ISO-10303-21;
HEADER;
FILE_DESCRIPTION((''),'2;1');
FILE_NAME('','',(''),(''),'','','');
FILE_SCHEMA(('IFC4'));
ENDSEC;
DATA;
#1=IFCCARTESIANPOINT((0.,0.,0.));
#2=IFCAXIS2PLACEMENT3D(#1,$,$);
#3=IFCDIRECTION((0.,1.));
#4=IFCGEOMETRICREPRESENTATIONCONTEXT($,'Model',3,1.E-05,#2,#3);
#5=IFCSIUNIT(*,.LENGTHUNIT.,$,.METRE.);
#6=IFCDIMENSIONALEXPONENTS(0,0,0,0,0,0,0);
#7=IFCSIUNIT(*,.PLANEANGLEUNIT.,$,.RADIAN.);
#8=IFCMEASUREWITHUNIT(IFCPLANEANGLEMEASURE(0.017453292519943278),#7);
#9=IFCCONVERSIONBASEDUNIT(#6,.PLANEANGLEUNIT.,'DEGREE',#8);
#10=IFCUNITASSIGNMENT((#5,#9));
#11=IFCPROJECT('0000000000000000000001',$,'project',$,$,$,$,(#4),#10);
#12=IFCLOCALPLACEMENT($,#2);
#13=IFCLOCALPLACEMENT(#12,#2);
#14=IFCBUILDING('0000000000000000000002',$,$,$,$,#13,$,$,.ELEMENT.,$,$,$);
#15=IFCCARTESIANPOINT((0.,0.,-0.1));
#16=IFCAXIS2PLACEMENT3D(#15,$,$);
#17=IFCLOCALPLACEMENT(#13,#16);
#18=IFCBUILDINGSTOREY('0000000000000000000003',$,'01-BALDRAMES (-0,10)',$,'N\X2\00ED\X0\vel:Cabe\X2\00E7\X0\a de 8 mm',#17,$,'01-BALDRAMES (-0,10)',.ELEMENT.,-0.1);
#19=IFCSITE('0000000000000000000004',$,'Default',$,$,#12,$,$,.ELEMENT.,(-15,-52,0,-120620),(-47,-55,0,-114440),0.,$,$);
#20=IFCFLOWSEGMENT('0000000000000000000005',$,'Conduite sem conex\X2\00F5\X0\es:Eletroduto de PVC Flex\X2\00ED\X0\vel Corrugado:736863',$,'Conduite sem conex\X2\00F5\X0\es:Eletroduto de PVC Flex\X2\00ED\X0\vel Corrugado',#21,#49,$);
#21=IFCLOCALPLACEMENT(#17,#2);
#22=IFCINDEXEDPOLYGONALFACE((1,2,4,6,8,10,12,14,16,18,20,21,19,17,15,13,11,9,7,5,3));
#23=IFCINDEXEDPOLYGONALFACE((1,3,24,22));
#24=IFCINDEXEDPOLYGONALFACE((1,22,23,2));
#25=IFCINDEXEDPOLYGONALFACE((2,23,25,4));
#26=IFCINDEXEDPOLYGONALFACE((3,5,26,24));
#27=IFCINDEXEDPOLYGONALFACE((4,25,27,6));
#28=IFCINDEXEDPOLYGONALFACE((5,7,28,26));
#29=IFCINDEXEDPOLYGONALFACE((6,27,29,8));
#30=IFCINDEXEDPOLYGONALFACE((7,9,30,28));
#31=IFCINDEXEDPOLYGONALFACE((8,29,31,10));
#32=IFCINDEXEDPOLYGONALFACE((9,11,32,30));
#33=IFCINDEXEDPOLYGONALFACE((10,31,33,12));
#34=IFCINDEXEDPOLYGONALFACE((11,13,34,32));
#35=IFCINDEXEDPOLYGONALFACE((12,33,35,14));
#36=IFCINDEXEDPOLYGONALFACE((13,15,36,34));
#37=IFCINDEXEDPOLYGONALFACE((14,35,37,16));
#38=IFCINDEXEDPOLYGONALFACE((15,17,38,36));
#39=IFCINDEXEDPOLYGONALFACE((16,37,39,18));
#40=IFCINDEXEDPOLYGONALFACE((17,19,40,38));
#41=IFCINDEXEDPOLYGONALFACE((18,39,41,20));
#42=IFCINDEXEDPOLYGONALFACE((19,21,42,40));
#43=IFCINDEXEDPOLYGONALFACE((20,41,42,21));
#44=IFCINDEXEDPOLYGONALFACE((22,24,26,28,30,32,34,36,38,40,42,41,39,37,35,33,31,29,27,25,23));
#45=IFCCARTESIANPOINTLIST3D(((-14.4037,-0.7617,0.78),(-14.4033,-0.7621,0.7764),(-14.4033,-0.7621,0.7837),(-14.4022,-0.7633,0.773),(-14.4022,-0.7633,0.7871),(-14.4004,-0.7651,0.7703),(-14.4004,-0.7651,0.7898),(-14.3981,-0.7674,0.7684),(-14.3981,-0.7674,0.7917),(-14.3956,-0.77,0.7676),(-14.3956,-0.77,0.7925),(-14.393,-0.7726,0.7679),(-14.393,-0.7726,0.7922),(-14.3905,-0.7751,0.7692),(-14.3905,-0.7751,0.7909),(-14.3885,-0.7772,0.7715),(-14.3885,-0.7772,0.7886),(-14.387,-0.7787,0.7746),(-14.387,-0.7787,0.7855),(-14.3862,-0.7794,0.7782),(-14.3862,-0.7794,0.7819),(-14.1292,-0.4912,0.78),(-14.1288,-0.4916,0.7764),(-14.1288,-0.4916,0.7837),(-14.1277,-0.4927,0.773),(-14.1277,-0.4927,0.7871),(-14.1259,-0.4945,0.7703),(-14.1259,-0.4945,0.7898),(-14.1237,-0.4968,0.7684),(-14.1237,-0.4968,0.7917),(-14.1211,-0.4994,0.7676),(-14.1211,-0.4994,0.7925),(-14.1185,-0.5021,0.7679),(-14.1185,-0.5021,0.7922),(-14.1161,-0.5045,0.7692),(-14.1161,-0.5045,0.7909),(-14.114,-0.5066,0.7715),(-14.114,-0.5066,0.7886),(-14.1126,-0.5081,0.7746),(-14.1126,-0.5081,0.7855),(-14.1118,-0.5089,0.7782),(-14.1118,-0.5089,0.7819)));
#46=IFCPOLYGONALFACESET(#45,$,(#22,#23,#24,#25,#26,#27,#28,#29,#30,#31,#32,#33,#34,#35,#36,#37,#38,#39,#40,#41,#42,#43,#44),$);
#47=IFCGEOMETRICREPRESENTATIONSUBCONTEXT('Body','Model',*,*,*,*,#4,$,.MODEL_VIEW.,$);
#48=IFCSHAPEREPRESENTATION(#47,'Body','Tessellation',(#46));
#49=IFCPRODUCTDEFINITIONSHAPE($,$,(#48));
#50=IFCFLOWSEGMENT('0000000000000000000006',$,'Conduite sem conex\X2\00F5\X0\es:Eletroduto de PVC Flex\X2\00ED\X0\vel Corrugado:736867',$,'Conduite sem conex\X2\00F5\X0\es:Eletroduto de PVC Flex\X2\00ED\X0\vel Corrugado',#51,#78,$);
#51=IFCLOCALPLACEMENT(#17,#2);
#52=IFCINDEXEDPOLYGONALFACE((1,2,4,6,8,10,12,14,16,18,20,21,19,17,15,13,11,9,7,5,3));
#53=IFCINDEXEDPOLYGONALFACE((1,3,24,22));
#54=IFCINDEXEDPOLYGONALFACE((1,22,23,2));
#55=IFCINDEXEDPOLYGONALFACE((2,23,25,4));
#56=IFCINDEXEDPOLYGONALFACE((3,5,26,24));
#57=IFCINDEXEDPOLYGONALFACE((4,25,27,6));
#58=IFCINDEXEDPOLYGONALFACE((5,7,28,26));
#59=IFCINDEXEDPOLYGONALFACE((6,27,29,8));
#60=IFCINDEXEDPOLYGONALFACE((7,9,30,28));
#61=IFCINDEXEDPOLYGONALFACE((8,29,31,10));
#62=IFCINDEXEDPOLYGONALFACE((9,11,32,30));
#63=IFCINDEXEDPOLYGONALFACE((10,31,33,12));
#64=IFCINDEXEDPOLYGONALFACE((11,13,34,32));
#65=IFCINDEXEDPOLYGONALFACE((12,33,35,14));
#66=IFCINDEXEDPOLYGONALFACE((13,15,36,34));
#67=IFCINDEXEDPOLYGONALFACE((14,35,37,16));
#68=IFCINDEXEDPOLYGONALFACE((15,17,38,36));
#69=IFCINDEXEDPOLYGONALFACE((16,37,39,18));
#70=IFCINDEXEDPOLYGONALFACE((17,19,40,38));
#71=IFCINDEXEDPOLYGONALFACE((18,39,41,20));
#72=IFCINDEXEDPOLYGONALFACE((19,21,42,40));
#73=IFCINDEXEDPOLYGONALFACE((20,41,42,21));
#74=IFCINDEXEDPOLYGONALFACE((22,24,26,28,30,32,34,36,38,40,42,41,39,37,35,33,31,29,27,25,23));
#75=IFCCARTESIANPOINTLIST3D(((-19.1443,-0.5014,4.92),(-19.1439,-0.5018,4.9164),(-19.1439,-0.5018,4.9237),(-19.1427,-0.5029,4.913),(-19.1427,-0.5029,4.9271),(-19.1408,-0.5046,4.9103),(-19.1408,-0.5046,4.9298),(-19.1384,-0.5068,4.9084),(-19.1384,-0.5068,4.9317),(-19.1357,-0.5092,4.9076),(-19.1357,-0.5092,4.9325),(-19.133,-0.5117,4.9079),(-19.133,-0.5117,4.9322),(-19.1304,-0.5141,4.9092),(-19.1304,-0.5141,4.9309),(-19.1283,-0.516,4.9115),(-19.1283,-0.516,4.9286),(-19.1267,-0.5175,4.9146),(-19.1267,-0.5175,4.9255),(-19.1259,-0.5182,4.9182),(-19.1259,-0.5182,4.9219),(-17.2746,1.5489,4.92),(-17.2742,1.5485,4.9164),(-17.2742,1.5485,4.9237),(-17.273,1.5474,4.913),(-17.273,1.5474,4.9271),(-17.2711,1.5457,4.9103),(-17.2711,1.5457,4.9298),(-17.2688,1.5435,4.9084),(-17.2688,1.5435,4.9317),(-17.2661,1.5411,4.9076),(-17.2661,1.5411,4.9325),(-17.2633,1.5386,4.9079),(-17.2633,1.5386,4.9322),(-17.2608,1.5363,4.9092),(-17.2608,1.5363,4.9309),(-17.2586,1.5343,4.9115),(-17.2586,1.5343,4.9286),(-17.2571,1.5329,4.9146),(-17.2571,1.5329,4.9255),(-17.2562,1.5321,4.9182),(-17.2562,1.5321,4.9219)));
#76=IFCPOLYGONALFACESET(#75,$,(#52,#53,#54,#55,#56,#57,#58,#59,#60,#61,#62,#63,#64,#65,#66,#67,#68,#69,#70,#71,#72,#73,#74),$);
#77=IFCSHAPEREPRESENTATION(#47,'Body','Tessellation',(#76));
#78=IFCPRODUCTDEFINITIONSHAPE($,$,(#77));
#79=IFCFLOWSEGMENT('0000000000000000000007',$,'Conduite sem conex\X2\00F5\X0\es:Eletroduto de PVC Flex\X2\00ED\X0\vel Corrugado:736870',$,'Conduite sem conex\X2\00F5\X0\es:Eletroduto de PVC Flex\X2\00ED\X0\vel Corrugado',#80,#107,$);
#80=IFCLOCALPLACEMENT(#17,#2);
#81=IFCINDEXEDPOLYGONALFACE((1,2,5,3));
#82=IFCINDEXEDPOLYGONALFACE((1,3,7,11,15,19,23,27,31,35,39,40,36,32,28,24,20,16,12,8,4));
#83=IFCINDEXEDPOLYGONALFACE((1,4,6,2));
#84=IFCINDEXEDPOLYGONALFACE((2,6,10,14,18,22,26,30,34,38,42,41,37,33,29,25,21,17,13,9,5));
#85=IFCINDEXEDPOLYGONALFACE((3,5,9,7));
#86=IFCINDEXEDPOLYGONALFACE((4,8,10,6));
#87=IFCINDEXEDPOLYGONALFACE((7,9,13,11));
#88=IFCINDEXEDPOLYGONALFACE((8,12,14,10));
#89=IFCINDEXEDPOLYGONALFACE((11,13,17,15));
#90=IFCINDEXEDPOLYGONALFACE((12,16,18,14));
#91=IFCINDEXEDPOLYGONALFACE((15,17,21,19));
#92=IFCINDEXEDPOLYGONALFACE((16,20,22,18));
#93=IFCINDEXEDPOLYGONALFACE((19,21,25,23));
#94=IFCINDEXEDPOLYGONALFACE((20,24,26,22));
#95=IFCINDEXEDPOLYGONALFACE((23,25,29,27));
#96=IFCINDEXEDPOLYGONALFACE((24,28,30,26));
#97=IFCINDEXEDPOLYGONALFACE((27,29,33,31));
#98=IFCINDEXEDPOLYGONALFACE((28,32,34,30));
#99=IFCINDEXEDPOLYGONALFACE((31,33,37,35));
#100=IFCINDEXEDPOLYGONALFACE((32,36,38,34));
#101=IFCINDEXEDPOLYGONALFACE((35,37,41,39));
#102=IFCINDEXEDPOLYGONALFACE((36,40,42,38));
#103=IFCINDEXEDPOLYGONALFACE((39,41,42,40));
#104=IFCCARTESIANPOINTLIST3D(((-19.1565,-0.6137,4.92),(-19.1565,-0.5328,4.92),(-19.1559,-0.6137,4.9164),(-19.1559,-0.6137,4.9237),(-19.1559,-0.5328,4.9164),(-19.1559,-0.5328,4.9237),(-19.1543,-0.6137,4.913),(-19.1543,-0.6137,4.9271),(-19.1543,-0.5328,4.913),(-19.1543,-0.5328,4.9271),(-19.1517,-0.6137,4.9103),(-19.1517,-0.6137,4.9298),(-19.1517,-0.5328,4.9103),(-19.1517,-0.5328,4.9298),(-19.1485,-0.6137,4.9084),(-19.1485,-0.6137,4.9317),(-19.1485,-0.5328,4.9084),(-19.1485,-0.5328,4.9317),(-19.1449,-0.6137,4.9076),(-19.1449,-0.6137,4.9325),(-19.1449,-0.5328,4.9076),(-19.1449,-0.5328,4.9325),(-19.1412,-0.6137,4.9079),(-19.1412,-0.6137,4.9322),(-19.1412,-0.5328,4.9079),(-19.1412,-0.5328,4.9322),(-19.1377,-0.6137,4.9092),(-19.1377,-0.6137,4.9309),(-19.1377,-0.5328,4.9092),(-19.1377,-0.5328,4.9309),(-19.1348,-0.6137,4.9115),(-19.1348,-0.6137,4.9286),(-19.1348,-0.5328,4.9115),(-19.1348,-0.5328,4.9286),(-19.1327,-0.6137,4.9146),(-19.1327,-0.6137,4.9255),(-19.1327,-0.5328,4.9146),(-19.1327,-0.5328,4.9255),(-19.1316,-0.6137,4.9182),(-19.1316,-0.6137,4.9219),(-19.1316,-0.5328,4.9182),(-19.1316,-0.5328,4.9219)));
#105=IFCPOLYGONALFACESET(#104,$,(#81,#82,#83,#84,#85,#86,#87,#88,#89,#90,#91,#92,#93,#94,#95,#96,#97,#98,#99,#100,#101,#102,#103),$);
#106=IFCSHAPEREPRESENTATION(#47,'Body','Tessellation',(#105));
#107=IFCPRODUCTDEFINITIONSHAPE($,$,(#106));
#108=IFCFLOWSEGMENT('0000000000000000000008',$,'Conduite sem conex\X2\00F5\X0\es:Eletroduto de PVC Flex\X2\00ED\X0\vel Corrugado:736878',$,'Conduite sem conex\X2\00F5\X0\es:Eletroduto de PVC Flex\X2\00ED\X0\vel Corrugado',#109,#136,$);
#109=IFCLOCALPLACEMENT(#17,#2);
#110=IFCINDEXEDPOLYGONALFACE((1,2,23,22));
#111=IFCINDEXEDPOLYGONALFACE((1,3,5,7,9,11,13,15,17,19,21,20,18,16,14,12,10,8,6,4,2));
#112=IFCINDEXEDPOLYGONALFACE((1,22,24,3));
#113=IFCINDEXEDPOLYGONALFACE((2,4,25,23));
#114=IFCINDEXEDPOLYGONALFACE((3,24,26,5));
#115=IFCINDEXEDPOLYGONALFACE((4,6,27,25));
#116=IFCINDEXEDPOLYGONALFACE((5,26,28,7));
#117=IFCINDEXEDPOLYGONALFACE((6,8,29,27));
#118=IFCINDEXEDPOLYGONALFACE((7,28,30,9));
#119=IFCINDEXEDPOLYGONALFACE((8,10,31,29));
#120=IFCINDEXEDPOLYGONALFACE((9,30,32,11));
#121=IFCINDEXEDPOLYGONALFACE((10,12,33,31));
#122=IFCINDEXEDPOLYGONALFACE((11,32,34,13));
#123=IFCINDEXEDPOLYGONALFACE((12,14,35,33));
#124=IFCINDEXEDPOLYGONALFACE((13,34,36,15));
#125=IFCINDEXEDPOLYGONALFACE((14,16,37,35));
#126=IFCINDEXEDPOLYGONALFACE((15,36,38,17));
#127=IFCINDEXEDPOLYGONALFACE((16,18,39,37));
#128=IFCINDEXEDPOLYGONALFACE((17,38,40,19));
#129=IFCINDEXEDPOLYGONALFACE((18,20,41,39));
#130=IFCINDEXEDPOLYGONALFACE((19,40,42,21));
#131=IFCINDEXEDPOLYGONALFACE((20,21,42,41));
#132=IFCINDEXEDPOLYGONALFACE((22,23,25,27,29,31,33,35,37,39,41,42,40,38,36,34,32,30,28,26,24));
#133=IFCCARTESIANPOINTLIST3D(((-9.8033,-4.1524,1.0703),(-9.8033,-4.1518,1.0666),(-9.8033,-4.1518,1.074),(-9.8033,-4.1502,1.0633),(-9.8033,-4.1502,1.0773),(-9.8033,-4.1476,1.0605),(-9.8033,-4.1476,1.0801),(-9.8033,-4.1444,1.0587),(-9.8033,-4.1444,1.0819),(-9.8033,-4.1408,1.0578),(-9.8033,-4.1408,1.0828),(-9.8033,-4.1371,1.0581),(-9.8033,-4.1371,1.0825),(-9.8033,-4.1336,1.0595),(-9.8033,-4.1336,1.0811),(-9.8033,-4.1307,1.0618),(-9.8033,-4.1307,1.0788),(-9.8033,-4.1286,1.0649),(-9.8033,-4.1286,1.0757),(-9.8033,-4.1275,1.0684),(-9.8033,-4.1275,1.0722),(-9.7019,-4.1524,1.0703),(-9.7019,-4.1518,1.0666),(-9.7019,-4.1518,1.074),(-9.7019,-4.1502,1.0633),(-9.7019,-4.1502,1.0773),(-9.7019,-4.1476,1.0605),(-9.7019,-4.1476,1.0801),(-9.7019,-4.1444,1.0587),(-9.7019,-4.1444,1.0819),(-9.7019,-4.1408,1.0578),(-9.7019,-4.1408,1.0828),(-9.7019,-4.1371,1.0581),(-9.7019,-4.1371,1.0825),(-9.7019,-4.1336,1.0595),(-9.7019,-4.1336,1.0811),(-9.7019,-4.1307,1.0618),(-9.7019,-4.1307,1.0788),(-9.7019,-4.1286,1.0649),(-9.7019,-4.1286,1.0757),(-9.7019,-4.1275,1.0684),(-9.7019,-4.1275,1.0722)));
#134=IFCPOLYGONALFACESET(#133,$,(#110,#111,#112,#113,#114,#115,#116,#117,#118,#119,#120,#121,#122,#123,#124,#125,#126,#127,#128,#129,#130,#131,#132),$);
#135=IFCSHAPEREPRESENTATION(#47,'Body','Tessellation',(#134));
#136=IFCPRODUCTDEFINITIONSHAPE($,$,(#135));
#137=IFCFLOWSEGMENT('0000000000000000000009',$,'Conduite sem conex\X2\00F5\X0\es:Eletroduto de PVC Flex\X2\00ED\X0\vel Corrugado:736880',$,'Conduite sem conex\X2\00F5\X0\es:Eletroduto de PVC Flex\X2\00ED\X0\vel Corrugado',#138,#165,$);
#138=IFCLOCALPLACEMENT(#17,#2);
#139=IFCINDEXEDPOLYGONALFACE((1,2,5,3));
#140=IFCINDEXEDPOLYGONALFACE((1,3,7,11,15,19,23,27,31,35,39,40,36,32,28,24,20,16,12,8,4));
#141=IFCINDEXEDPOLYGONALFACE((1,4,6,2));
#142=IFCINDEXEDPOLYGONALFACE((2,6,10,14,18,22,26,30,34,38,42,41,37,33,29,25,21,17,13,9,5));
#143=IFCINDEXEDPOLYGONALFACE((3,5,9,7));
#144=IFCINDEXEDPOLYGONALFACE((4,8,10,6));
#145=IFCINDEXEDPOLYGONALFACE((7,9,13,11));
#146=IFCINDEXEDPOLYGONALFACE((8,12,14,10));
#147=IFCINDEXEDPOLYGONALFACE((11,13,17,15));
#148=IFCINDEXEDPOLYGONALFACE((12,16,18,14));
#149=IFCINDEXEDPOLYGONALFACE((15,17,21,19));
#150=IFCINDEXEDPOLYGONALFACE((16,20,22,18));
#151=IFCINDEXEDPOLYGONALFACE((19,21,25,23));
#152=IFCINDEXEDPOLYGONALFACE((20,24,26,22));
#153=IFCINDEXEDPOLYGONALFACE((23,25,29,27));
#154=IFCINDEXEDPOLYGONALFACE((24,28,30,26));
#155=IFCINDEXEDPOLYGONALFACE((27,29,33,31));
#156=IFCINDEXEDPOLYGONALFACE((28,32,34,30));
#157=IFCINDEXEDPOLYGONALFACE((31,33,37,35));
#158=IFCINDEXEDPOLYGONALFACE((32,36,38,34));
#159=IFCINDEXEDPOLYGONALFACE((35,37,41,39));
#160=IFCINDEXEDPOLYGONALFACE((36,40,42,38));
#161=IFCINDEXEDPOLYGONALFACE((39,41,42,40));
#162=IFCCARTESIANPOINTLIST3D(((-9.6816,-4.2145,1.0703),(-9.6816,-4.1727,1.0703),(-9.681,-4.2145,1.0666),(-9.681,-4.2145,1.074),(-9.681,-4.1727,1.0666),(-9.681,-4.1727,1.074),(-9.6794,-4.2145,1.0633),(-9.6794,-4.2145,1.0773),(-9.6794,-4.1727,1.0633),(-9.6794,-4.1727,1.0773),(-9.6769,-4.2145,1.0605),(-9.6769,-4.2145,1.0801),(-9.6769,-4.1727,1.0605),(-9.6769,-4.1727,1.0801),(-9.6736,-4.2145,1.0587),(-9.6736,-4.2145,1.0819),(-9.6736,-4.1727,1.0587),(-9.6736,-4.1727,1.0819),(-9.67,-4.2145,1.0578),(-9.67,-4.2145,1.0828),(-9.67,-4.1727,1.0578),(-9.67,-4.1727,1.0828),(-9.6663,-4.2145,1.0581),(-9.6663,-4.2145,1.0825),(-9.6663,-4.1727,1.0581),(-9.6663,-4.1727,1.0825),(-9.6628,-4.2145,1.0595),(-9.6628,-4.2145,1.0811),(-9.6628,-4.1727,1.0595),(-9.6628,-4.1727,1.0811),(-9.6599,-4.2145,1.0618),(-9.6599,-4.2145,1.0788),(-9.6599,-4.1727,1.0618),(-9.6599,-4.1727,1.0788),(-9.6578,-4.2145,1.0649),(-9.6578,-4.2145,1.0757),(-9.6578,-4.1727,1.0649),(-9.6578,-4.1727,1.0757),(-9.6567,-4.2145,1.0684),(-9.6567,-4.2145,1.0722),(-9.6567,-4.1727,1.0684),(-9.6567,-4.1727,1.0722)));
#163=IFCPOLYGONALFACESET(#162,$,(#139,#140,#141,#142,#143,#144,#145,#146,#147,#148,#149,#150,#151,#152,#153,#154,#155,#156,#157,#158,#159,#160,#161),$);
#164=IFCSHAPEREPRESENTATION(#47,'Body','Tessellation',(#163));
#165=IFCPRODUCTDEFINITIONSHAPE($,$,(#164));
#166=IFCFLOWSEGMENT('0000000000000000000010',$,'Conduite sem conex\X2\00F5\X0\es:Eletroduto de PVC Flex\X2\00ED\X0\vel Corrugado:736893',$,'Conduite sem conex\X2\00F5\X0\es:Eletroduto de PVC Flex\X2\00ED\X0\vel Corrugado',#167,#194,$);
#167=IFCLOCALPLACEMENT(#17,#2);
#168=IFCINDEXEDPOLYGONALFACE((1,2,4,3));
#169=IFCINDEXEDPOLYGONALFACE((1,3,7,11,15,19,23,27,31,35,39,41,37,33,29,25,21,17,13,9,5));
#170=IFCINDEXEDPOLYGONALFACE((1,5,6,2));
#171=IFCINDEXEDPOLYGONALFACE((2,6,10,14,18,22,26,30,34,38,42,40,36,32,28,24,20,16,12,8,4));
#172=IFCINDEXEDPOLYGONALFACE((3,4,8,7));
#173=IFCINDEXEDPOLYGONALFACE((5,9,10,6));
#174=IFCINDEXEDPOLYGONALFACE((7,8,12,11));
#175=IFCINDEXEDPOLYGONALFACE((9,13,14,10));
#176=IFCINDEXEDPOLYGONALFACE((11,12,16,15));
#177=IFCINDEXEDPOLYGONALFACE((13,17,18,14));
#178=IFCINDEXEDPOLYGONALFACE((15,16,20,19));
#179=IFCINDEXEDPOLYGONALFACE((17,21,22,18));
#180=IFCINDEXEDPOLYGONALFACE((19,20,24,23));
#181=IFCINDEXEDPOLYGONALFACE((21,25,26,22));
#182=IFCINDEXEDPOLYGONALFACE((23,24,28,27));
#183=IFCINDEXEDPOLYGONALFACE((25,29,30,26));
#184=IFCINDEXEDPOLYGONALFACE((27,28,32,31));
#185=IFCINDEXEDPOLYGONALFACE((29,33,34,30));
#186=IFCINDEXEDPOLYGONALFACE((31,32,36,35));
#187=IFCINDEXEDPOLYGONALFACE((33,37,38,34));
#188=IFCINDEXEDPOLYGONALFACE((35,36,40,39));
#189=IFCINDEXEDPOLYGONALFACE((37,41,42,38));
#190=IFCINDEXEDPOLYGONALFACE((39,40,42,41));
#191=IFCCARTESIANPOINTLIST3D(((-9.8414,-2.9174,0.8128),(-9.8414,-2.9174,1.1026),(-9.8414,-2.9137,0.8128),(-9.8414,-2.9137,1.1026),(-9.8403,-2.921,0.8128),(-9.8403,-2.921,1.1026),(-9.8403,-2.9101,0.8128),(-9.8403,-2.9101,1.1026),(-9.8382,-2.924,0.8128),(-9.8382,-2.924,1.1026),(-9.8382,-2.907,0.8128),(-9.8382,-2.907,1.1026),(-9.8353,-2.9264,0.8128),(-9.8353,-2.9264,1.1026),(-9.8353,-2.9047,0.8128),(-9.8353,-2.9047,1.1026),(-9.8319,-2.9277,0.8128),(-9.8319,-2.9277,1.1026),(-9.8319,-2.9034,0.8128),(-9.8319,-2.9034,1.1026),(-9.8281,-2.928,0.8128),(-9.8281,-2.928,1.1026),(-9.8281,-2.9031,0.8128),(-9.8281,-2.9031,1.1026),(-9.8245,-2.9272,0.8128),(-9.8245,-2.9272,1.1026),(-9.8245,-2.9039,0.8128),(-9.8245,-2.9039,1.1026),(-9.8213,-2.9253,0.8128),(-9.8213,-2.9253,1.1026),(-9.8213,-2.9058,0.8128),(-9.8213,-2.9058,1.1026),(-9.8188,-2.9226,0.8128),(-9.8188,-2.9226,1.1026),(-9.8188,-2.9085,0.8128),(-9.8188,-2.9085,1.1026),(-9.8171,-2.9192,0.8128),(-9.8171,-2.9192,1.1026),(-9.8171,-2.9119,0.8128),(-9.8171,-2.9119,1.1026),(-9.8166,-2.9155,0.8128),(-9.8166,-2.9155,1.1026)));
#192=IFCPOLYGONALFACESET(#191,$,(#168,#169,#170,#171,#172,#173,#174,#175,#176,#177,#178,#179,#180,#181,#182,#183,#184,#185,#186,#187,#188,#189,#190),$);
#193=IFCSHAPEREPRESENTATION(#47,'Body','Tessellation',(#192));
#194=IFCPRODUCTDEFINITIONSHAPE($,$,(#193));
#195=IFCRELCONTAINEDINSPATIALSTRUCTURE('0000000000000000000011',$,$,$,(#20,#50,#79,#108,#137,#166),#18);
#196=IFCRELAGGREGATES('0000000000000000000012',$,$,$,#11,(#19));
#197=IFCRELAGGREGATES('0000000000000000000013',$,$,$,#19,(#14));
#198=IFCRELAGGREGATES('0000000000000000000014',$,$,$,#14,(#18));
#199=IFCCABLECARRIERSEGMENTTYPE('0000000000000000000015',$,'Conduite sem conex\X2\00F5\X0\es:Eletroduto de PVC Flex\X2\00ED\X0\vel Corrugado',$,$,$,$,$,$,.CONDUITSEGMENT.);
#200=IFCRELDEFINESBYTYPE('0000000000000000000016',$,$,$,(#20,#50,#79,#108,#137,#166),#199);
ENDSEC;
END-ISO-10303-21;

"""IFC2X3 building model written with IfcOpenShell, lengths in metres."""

from ifc_helpers import new_model, entity, si_unit, converted_unit, direction, frame, frame_2d, origin, origin_2d_with_axis, place, context, subcontext, project, spatial, circle, extrude, type_object, element, save


model = new_model("IFC2X3")

# Units and contexts
model_context = context("Model", 3, precision=1e-05, world=origin(), true_north=direction((0.0, 1.0)))
body_context = subcontext(model_context, "Body", "Model", "MODEL_VIEW")
ifc_project = project(units=[si_unit("LENGTHUNIT", "METRE"), converted_unit("PLANEANGLEUNIT", "DEGREE", entity("IfcPlaneAngleMeasure", 0.017453292519943278), si_unit("PLANEANGLEUNIT", "RADIAN"), dimensions=[0, 0, 0, 0, 0, 0, 0])], contexts=[model_context])

# Site, building, storey
site_placement = place(None, origin())
site = spatial("IfcSite", under=ifc_project, at=site_placement, Name="Default", CompositionType="ELEMENT", RefLatitude=(-15, -52, 0, -120620), RefLongitude=(-47, -55, 0, -114440), RefElevation=0.0)
building_placement = place(site_placement, origin())
building = spatial("IfcBuilding", under=site, at=building_placement, CompositionType="ELEMENT")
storey_placement = place(building_placement, frame((0.0, 0.0, -0.1)))
storey = spatial("IfcBuildingStorey", under=building, at=storey_placement, Name="01-BALDRAMES (-0,10)", ObjectType="Nível:Cabeça de 8 mm", LongName="01-BALDRAMES (-0,10)", CompositionType="ELEMENT", Elevation=-0.1)

# Flow segments
cable_carrier_segment_type = type_object("IfcCableCarrierSegmentType", Name="Conduite sem conexões:Eletroduto de PVC Flexível Corrugado", PredefinedType="CONDUITSEGMENT")
flow_segment_1_placement = place(storey_placement, origin())
element("IfcFlowSegment", 1, at=flow_segment_1_placement, inside=storey, type_object=cable_carrier_segment_type, Name="Conduite sem conexões:Eletroduto de PVC Flexível Corrugado:736863", ObjectType="Conduite sem conexões:Eletroduto de PVC Flexível Corrugado", context=body_context, shape_type="SweptSolid", body=[
    extrude(circle(Radius=0.0125, at=origin_2d_with_axis()), frame((-14.3949, -0.7706, 0.78), z_axis=(0.712135, 0.702042, 0.0), x_axis=(-0.702042, 0.712135, 0.0)), (0.0, 0.0, 1.0), 0.3854),
])
flow_segment_2_placement = place(storey_placement, origin())
element("IfcFlowSegment", 2, at=flow_segment_2_placement, inside=storey, type_object=cable_carrier_segment_type, Name="Conduite sem conexões:Eletroduto de PVC Flexível Corrugado:736867", ObjectType="Conduite sem conexões:Eletroduto de PVC Flexível Corrugado", context=body_context, shape_type="SweptSolid", body=[
    extrude(circle(Radius=0.0125, at=frame_2d((0.0, 0.0), x_axis=(1.0, 0.0))), frame((-19.1351, -0.5099, 4.92), z_axis=(0.673804, 0.73891, 0.0), x_axis=(-0.73891, 0.673804, 0.0)), (0.0, 0.0, 1.0), 2.7748),
])
flow_segment_3_placement = place(storey_placement, origin())
element("IfcFlowSegment", 3, at=flow_segment_3_placement, inside=storey, type_object=cable_carrier_segment_type, Name="Conduite sem conexões:Eletroduto de PVC Flexível Corrugado:736870", ObjectType="Conduite sem conexões:Eletroduto de PVC Flexível Corrugado", context=body_context, shape_type="SweptSolid", body=[
    extrude(circle(Radius=0.0125, at=frame_2d((0.0, 0.0), x_axis=(1.0, 0.0))), frame((-19.144, -0.6137, 4.92), z_axis=(0.0, 1.0, 0.0), x_axis=(-1.0, 0.0, 0.0)), (0.0, 0.0, 1.0), 0.0809),
])
flow_segment_4_placement = place(storey_placement, origin())
element("IfcFlowSegment", 4, at=flow_segment_4_placement, inside=storey, type_object=cable_carrier_segment_type, Name="Conduite sem conexões:Eletroduto de PVC Flexível Corrugado:736878", ObjectType="Conduite sem conexões:Eletroduto de PVC Flexível Corrugado", context=body_context, shape_type="SweptSolid", body=[
    extrude(circle(Radius=0.0125, at=origin_2d_with_axis()), frame((-9.8033, -4.1399, 1.0703), z_axis=(1.0, 0.0, 0.0), x_axis=(0.0, -1.0, 0.0)), (0.0, 0.0, 1.0), 0.1014),
])
flow_segment_5_placement = place(storey_placement, origin())
element("IfcFlowSegment", 5, at=flow_segment_5_placement, inside=storey, type_object=cable_carrier_segment_type, Name="Conduite sem conexões:Eletroduto de PVC Flexível Corrugado:736880", ObjectType="Conduite sem conexões:Eletroduto de PVC Flexível Corrugado", context=body_context, shape_type="SweptSolid", body=[
    extrude(circle(Radius=0.0125, at=frame_2d((0.0, 0.0), x_axis=(1.0, 0.0))), frame((-9.6691, -4.2145, 1.0703), z_axis=(0.0, 1.0, 0.0), x_axis=(-1.0, 0.0, 0.0)), (0.0, 0.0, 1.0), 0.0419),
])
flow_segment_6_placement = place(storey_placement, origin())
element("IfcFlowSegment", 6, at=flow_segment_6_placement, inside=storey, type_object=cable_carrier_segment_type, Name="Conduite sem conexões:Eletroduto de PVC Flexível Corrugado:736893", ObjectType="Conduite sem conexões:Eletroduto de PVC Flexível Corrugado", context=body_context, shape_type="SweptSolid", body=[
    extrude(circle(Radius=0.0125, at=frame_2d((0.0, 0.0), x_axis=(1.0, 0.0))), frame((-9.8291, -2.9155, 0.8128)), (0.0, 0.0, 1.0), 0.2898),
])

save(model, "model.ifc")
